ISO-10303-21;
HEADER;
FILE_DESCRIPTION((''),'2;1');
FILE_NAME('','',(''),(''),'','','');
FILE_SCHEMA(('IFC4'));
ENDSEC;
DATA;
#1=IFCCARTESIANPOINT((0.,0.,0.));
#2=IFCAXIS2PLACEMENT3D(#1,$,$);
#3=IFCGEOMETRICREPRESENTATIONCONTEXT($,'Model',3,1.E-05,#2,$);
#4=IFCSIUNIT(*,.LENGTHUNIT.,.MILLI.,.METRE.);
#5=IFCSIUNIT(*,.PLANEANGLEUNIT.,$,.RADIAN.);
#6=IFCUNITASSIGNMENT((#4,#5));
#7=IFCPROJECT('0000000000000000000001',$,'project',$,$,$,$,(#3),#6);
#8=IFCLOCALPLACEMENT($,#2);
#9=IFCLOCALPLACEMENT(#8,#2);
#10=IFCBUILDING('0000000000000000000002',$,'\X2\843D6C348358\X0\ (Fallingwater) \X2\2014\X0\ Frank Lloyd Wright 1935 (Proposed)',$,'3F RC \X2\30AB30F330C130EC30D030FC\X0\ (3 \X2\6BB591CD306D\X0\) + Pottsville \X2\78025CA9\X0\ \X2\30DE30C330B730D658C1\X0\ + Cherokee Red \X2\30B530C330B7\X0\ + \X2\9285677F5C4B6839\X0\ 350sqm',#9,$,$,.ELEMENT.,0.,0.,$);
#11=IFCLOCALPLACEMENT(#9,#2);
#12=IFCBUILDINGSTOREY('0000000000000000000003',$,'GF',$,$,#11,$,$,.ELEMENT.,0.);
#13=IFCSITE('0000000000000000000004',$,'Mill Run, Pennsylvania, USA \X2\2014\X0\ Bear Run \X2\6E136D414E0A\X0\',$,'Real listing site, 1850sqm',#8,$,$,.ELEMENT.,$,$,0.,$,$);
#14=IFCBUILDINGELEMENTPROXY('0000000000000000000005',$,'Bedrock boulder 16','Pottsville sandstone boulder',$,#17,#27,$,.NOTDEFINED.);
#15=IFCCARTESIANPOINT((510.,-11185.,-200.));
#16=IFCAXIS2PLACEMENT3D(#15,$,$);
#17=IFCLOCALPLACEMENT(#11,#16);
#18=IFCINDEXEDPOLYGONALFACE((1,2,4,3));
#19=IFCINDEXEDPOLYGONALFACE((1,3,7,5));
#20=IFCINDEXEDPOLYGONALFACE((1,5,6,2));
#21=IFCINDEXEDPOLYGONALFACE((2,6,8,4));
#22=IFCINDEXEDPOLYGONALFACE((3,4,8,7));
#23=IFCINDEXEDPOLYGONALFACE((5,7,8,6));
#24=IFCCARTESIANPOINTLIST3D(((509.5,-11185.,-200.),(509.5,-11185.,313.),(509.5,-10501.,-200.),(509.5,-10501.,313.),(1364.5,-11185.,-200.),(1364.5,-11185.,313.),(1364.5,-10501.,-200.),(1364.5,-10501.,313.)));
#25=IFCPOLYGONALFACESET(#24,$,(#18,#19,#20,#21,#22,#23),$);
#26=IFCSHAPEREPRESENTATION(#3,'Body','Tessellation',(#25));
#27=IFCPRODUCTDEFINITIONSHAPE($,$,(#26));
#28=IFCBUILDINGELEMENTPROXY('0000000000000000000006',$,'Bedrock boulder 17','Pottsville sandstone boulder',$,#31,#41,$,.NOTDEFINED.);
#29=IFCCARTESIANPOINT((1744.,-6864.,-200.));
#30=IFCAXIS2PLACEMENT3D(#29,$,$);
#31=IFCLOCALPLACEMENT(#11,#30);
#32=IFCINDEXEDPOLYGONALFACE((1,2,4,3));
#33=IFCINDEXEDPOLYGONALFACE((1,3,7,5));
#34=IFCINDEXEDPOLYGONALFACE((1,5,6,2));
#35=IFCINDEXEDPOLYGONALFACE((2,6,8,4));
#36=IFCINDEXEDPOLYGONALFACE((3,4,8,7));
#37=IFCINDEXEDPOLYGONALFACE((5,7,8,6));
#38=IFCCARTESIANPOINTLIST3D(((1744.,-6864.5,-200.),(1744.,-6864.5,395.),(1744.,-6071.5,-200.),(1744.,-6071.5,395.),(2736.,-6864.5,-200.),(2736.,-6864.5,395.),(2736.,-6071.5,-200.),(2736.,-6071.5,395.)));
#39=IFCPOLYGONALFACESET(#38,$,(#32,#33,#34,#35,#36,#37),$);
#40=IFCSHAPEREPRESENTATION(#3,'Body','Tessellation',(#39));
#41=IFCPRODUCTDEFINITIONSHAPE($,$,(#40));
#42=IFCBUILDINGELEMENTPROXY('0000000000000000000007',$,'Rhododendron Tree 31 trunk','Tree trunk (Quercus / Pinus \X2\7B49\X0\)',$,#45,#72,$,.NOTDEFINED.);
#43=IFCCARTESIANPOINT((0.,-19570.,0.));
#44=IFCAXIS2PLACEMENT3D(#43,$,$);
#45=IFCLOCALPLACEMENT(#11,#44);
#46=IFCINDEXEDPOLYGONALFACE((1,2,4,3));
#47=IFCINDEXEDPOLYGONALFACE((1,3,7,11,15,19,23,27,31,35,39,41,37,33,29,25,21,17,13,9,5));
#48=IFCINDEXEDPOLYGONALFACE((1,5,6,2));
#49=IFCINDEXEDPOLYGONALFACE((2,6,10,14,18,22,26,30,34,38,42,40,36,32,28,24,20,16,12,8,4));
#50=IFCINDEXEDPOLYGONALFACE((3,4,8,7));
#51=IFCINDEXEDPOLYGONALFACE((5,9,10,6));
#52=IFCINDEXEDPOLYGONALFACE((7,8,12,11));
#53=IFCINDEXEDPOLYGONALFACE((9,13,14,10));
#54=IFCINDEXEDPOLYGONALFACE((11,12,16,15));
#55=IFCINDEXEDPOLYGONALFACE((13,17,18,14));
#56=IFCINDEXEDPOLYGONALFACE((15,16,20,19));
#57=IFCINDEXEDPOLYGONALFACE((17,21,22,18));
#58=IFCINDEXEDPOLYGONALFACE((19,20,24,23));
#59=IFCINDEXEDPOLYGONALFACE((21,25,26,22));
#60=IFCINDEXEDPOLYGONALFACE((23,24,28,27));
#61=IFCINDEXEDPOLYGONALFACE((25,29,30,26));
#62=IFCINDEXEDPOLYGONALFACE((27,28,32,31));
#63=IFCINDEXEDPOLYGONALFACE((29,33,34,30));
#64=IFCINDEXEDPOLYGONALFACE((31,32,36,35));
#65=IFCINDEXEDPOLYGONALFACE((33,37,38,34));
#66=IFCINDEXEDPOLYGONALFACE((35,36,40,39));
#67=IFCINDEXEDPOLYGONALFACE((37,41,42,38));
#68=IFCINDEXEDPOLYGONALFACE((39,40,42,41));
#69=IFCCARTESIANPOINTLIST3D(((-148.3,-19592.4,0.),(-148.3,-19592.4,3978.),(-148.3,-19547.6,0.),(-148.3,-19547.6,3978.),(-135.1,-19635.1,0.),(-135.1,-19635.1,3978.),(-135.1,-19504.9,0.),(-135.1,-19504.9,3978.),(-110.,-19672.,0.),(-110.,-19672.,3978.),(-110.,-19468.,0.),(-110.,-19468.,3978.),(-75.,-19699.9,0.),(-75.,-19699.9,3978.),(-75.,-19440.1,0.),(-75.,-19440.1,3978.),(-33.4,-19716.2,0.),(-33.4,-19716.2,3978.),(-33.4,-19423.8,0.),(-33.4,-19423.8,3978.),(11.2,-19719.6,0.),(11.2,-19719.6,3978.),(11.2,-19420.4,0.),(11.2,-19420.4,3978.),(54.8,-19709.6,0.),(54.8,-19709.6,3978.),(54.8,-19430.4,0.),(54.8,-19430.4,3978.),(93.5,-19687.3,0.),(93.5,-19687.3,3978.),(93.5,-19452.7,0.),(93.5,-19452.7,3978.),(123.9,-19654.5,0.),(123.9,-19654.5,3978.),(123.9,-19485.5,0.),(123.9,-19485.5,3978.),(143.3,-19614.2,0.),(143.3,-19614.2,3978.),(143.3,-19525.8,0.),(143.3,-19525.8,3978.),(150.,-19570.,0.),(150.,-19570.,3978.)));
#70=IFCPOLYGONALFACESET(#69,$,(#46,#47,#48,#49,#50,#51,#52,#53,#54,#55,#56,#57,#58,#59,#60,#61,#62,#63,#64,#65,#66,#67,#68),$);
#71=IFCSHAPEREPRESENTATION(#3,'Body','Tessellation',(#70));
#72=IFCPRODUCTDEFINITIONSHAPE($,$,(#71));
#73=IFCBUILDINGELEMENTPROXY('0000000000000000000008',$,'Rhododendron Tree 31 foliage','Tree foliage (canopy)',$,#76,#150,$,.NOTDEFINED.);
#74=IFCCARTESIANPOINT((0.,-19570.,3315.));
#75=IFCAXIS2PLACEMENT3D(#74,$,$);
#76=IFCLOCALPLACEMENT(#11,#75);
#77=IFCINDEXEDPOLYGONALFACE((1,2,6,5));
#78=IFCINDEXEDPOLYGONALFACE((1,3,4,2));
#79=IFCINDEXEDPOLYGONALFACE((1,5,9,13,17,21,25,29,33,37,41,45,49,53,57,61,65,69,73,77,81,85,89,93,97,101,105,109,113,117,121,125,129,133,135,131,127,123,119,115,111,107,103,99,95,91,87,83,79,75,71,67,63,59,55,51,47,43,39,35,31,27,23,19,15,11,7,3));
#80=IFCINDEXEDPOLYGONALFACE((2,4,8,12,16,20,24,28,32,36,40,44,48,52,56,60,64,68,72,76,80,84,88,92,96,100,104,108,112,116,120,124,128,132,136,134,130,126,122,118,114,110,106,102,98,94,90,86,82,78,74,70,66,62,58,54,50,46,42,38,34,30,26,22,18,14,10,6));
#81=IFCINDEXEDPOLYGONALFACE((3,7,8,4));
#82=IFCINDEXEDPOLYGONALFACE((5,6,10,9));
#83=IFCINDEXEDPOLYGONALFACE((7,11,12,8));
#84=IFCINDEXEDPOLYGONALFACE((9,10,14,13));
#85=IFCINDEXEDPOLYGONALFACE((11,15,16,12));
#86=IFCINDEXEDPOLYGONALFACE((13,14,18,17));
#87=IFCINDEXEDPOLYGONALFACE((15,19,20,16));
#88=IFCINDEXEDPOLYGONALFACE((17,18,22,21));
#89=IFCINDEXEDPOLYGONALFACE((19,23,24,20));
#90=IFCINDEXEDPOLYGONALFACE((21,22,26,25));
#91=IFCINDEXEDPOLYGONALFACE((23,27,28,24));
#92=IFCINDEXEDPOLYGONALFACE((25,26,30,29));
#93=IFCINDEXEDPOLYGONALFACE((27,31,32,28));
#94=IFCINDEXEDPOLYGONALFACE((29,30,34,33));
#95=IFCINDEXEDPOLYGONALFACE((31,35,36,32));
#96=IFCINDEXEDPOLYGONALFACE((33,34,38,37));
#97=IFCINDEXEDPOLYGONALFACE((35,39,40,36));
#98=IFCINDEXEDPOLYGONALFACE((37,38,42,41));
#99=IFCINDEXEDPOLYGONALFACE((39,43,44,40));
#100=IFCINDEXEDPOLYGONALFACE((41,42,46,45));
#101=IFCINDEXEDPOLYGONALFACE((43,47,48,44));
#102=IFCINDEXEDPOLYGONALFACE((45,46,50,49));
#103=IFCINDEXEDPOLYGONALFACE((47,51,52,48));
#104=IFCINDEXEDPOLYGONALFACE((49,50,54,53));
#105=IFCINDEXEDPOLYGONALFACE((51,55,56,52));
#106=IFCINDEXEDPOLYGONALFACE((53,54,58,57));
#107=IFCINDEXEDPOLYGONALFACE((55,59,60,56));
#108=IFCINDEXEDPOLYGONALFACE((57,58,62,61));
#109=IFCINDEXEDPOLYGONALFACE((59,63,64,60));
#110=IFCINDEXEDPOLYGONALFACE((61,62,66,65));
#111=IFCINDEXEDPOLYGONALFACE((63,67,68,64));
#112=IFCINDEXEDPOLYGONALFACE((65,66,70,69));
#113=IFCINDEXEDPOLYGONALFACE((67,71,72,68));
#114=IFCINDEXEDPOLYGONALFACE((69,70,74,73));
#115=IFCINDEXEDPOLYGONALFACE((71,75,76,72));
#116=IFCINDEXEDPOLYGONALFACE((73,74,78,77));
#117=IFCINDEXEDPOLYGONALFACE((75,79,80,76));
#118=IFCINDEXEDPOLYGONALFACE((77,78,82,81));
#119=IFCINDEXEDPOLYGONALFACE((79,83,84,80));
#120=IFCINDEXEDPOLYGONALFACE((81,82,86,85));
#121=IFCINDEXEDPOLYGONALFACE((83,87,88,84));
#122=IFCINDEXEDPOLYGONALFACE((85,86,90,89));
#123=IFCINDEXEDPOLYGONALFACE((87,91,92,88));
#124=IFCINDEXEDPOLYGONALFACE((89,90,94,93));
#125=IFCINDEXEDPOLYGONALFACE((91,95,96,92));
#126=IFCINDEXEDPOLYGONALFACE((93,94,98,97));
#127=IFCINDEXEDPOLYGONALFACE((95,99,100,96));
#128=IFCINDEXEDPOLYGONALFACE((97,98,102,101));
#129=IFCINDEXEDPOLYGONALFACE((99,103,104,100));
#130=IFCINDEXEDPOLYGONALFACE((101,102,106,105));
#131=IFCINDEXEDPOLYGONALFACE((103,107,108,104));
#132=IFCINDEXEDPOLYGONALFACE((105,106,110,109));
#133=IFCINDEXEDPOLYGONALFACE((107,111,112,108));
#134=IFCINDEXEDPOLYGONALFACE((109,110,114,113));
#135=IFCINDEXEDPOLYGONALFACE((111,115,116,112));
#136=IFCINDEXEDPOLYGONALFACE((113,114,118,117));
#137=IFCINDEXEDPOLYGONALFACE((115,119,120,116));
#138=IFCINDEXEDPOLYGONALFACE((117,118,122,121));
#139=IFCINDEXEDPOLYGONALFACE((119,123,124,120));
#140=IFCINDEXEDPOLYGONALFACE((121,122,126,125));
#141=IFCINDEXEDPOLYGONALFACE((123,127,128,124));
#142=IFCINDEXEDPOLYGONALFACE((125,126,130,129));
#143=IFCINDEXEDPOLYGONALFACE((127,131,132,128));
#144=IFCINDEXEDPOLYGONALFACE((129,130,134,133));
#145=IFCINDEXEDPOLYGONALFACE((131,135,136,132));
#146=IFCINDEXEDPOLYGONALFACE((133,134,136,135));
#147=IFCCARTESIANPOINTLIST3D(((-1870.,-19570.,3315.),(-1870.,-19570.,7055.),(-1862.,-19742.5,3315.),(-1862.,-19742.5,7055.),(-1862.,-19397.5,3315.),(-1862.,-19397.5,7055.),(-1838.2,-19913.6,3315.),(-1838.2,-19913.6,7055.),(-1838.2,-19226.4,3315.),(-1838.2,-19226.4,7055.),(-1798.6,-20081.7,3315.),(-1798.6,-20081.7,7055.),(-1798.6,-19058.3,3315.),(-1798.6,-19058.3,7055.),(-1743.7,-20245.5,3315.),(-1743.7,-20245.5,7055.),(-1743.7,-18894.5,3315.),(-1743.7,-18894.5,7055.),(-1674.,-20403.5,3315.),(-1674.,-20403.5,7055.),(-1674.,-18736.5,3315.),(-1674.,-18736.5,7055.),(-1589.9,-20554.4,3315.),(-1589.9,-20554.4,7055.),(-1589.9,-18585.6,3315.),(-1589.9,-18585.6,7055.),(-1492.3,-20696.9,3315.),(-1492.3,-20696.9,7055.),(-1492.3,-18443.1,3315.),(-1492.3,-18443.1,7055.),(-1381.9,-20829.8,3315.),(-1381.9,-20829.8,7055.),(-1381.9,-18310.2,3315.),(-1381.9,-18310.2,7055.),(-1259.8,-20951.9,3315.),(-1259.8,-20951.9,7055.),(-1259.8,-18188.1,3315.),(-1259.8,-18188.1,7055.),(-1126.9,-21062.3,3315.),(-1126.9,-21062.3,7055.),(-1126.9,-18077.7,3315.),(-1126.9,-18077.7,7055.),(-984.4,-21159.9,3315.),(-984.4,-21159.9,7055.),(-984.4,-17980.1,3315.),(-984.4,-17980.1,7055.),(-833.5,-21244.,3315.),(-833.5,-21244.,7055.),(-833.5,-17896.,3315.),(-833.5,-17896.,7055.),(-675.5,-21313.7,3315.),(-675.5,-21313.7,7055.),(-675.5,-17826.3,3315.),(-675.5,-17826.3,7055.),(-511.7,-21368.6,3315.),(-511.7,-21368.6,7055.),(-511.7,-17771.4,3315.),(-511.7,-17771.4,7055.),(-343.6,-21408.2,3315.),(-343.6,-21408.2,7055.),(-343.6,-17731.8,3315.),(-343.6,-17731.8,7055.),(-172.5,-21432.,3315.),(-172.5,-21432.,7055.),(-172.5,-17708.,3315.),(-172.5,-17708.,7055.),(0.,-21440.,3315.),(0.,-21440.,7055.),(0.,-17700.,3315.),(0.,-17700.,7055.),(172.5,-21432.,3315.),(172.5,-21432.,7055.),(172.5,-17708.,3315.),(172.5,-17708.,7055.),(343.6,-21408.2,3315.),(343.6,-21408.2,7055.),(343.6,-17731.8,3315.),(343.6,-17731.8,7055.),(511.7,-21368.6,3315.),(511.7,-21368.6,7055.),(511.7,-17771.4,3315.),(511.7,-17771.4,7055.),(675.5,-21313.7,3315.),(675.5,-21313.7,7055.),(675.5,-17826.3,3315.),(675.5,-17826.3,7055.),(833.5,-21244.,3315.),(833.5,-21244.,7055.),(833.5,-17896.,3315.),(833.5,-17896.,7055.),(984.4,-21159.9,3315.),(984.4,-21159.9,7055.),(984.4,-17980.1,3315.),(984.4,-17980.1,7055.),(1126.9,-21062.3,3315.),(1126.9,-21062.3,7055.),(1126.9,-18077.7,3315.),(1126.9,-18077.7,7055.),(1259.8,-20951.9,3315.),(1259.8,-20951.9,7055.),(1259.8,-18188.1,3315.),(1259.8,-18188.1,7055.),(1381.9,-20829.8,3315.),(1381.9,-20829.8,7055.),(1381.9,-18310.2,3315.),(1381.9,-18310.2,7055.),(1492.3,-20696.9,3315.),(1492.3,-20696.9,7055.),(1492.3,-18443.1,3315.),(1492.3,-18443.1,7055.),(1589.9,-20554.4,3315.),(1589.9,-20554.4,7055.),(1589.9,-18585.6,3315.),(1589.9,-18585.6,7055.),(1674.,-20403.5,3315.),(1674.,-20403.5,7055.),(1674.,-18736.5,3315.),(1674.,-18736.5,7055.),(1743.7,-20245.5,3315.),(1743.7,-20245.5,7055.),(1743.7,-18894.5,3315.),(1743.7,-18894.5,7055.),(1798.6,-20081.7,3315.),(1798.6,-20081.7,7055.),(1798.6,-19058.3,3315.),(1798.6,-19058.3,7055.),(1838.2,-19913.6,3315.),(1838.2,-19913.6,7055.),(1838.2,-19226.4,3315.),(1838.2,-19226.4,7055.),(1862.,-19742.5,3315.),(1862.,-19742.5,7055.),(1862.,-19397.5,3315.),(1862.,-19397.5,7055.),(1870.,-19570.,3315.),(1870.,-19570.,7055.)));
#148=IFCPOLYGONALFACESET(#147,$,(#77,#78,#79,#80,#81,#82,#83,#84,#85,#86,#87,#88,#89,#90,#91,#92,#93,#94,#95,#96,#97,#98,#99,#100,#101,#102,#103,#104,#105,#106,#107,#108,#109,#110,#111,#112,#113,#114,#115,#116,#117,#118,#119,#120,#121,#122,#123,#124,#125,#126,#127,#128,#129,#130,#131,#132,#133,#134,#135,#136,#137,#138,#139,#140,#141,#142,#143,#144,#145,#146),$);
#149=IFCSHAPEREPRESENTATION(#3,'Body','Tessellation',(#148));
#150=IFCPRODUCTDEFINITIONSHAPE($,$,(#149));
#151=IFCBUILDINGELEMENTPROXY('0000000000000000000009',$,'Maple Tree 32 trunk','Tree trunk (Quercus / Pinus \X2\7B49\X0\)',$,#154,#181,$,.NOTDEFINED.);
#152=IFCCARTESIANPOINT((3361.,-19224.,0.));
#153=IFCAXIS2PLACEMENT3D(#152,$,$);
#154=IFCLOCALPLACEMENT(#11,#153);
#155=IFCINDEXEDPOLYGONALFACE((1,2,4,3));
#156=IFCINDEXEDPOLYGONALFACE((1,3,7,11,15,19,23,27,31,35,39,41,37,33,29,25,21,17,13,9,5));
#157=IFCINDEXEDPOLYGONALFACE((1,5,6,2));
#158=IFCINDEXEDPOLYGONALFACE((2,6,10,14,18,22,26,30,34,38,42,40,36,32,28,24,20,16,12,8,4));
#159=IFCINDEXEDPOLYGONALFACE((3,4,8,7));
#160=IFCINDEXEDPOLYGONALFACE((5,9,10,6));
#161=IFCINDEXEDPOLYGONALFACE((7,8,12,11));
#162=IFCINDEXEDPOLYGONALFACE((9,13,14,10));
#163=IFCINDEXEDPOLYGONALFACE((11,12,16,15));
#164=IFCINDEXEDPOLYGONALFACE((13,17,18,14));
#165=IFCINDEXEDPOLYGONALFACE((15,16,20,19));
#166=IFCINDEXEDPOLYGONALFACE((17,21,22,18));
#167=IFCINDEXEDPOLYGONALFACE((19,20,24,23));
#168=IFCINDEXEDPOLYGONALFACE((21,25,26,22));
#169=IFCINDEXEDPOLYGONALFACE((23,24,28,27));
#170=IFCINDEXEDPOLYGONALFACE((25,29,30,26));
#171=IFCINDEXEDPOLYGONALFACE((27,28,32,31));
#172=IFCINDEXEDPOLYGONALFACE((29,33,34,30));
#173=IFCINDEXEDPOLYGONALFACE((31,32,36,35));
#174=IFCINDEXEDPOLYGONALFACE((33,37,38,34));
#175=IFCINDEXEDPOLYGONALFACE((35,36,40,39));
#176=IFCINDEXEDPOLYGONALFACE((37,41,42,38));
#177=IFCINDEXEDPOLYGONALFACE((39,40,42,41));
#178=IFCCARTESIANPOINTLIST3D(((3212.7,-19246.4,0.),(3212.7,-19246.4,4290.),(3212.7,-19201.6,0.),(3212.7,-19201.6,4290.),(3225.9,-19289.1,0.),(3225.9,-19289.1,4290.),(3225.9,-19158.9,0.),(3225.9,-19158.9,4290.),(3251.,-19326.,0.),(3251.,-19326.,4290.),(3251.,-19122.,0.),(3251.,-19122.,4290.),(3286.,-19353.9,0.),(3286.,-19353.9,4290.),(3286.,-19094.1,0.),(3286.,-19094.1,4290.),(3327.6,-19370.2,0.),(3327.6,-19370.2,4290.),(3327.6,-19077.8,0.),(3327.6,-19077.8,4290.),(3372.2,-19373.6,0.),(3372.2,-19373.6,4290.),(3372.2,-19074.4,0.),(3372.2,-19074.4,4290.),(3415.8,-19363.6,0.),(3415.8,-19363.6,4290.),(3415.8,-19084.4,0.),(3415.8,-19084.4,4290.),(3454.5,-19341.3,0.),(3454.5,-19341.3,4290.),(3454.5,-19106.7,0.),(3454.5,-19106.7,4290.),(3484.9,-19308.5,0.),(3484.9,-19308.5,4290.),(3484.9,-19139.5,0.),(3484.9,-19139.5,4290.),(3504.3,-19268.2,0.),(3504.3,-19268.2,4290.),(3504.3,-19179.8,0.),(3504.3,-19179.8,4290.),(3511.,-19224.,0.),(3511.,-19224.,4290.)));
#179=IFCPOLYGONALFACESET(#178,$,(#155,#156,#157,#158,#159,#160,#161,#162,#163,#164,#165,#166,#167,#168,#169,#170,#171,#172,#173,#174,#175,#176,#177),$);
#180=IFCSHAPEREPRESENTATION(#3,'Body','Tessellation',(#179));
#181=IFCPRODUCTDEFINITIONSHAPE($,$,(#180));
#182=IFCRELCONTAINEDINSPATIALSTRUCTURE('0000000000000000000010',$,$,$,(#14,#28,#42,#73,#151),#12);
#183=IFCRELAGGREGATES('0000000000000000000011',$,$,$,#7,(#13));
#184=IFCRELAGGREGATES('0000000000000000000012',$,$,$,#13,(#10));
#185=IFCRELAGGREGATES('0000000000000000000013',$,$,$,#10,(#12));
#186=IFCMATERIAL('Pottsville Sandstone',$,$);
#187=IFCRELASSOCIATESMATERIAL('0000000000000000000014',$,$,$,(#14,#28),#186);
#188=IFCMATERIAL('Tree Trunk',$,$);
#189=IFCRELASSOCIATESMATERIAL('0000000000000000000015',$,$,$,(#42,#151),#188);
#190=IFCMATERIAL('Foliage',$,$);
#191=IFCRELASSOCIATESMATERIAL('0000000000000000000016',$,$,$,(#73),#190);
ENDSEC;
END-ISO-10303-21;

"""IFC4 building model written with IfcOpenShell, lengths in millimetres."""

from ifc_helpers import new_model, si_unit, frame, frame_2d, origin, origin_2d, place, context, project, spatial, rectangle, circle, extrude, material, element, save


model = new_model("IFC4")

# Units and contexts
model_context = context("Model", 3, precision=1e-05, world=origin())
ifc_project = project(units=[si_unit("LENGTHUNIT", "METRE", prefix="MILLI"), si_unit("PLANEANGLEUNIT", "RADIAN")], contexts=[model_context])

# Site, building, storey
site_placement = place(None, origin())
site = spatial("IfcSite", under=ifc_project, at=site_placement, Name="Mill Run, Pennsylvania, USA — Bear Run 渓流上", ObjectType="Real listing site, 1850sqm", CompositionType="ELEMENT", RefElevation=0.0)
building_placement = place(site_placement, origin())
building = spatial("IfcBuilding", under=site, at=building_placement, Name="落水荘 (Fallingwater) — Frank Lloyd Wright 1935 (Proposed)", ObjectType="3F RC カンチレバー (3 段重ね) + Pottsville 砂岩 マッシブ壁 + Cherokee Red サッシ + 銅板屋根 350sqm", CompositionType="ELEMENT", ElevationOfRefHeight=0.0, ElevationOfTerrain=0.0)
storey_placement = place(building_placement, origin())
storey = spatial("IfcBuildingStorey", under=building, at=storey_placement, Name="GF", CompositionType="ELEMENT", Elevation=0.0)

# Building element proxies
ifc_material_1 = material(Name="Pottsville Sandstone")
proxy_1_placement = place(storey_placement, frame((510.0, -11185.0, -200.0)))
element("IfcBuildingElementProxy", 1, at=proxy_1_placement, inside=storey, material=ifc_material_1, Name="Bedrock boulder 16", Description="Pottsville sandstone boulder", PredefinedType="NOTDEFINED", context=model_context, shape_type="SweptSolid", body=[
    extrude(rectangle(XDim=855.0, YDim=684.0, at=frame_2d((427.0, 342.0))), frame((510.0, -11185.0, -200.0)), (0.0, 0.0, 1.0), 513.0),
])
proxy_2_placement = place(storey_placement, frame((1744.0, -6864.0, -200.0)))
element("IfcBuildingElementProxy", 2, at=proxy_2_placement, inside=storey, material=ifc_material_1, Name="Bedrock boulder 17", Description="Pottsville sandstone boulder", PredefinedType="NOTDEFINED", context=model_context, shape_type="SweptSolid", body=[
    extrude(rectangle(XDim=992.0, YDim=793.0, at=frame_2d((496.0, 396.0))), frame((1744.0, -6864.0, -200.0)), (0.0, 0.0, 1.0), 595.0),
])
ifc_material_2 = material(Name="Tree Trunk")
proxy_3_placement = place(storey_placement, frame((0.0, -19570.0, 0.0)))
element("IfcBuildingElementProxy", 3, at=proxy_3_placement, inside=storey, material=ifc_material_2, Name="Rhododendron Tree 31 trunk", Description="Tree trunk (Quercus / Pinus 等)", PredefinedType="NOTDEFINED", context=model_context, shape_type="SweptSolid", body=[
    extrude(circle(Radius=150.0, at=origin_2d()), frame((0.0, -19570.0, 0.0)), (0.0, 0.0, 1.0), 3978.0),
])
ifc_material_3 = material(Name="Foliage")
proxy_4_placement = place(storey_placement, frame((0.0, -19570.0, 3315.0)))
element("IfcBuildingElementProxy", 4, at=proxy_4_placement, inside=storey, material=ifc_material_3, Name="Rhododendron Tree 31 foliage", Description="Tree foliage (canopy)", PredefinedType="NOTDEFINED", context=model_context, shape_type="SweptSolid", body=[
    extrude(circle(Radius=1870.0, at=origin_2d()), frame((0.0, -19570.0, 3315.0)), (0.0, 0.0, 1.0), 3740.0),
])
proxy_5_placement = place(storey_placement, frame((3361.0, -19224.0, 0.0)))
element("IfcBuildingElementProxy", 5, at=proxy_5_placement, inside=storey, material=ifc_material_2, Name="Maple Tree 32 trunk", Description="Tree trunk (Quercus / Pinus 等)", PredefinedType="NOTDEFINED", context=model_context, shape_type="SweptSolid", body=[
    extrude(circle(Radius=150.0, at=origin_2d()), frame((3361.0, -19224.0, 0.0)), (0.0, 0.0, 1.0), 4290.0),
])

save(model, "model.ifc")
